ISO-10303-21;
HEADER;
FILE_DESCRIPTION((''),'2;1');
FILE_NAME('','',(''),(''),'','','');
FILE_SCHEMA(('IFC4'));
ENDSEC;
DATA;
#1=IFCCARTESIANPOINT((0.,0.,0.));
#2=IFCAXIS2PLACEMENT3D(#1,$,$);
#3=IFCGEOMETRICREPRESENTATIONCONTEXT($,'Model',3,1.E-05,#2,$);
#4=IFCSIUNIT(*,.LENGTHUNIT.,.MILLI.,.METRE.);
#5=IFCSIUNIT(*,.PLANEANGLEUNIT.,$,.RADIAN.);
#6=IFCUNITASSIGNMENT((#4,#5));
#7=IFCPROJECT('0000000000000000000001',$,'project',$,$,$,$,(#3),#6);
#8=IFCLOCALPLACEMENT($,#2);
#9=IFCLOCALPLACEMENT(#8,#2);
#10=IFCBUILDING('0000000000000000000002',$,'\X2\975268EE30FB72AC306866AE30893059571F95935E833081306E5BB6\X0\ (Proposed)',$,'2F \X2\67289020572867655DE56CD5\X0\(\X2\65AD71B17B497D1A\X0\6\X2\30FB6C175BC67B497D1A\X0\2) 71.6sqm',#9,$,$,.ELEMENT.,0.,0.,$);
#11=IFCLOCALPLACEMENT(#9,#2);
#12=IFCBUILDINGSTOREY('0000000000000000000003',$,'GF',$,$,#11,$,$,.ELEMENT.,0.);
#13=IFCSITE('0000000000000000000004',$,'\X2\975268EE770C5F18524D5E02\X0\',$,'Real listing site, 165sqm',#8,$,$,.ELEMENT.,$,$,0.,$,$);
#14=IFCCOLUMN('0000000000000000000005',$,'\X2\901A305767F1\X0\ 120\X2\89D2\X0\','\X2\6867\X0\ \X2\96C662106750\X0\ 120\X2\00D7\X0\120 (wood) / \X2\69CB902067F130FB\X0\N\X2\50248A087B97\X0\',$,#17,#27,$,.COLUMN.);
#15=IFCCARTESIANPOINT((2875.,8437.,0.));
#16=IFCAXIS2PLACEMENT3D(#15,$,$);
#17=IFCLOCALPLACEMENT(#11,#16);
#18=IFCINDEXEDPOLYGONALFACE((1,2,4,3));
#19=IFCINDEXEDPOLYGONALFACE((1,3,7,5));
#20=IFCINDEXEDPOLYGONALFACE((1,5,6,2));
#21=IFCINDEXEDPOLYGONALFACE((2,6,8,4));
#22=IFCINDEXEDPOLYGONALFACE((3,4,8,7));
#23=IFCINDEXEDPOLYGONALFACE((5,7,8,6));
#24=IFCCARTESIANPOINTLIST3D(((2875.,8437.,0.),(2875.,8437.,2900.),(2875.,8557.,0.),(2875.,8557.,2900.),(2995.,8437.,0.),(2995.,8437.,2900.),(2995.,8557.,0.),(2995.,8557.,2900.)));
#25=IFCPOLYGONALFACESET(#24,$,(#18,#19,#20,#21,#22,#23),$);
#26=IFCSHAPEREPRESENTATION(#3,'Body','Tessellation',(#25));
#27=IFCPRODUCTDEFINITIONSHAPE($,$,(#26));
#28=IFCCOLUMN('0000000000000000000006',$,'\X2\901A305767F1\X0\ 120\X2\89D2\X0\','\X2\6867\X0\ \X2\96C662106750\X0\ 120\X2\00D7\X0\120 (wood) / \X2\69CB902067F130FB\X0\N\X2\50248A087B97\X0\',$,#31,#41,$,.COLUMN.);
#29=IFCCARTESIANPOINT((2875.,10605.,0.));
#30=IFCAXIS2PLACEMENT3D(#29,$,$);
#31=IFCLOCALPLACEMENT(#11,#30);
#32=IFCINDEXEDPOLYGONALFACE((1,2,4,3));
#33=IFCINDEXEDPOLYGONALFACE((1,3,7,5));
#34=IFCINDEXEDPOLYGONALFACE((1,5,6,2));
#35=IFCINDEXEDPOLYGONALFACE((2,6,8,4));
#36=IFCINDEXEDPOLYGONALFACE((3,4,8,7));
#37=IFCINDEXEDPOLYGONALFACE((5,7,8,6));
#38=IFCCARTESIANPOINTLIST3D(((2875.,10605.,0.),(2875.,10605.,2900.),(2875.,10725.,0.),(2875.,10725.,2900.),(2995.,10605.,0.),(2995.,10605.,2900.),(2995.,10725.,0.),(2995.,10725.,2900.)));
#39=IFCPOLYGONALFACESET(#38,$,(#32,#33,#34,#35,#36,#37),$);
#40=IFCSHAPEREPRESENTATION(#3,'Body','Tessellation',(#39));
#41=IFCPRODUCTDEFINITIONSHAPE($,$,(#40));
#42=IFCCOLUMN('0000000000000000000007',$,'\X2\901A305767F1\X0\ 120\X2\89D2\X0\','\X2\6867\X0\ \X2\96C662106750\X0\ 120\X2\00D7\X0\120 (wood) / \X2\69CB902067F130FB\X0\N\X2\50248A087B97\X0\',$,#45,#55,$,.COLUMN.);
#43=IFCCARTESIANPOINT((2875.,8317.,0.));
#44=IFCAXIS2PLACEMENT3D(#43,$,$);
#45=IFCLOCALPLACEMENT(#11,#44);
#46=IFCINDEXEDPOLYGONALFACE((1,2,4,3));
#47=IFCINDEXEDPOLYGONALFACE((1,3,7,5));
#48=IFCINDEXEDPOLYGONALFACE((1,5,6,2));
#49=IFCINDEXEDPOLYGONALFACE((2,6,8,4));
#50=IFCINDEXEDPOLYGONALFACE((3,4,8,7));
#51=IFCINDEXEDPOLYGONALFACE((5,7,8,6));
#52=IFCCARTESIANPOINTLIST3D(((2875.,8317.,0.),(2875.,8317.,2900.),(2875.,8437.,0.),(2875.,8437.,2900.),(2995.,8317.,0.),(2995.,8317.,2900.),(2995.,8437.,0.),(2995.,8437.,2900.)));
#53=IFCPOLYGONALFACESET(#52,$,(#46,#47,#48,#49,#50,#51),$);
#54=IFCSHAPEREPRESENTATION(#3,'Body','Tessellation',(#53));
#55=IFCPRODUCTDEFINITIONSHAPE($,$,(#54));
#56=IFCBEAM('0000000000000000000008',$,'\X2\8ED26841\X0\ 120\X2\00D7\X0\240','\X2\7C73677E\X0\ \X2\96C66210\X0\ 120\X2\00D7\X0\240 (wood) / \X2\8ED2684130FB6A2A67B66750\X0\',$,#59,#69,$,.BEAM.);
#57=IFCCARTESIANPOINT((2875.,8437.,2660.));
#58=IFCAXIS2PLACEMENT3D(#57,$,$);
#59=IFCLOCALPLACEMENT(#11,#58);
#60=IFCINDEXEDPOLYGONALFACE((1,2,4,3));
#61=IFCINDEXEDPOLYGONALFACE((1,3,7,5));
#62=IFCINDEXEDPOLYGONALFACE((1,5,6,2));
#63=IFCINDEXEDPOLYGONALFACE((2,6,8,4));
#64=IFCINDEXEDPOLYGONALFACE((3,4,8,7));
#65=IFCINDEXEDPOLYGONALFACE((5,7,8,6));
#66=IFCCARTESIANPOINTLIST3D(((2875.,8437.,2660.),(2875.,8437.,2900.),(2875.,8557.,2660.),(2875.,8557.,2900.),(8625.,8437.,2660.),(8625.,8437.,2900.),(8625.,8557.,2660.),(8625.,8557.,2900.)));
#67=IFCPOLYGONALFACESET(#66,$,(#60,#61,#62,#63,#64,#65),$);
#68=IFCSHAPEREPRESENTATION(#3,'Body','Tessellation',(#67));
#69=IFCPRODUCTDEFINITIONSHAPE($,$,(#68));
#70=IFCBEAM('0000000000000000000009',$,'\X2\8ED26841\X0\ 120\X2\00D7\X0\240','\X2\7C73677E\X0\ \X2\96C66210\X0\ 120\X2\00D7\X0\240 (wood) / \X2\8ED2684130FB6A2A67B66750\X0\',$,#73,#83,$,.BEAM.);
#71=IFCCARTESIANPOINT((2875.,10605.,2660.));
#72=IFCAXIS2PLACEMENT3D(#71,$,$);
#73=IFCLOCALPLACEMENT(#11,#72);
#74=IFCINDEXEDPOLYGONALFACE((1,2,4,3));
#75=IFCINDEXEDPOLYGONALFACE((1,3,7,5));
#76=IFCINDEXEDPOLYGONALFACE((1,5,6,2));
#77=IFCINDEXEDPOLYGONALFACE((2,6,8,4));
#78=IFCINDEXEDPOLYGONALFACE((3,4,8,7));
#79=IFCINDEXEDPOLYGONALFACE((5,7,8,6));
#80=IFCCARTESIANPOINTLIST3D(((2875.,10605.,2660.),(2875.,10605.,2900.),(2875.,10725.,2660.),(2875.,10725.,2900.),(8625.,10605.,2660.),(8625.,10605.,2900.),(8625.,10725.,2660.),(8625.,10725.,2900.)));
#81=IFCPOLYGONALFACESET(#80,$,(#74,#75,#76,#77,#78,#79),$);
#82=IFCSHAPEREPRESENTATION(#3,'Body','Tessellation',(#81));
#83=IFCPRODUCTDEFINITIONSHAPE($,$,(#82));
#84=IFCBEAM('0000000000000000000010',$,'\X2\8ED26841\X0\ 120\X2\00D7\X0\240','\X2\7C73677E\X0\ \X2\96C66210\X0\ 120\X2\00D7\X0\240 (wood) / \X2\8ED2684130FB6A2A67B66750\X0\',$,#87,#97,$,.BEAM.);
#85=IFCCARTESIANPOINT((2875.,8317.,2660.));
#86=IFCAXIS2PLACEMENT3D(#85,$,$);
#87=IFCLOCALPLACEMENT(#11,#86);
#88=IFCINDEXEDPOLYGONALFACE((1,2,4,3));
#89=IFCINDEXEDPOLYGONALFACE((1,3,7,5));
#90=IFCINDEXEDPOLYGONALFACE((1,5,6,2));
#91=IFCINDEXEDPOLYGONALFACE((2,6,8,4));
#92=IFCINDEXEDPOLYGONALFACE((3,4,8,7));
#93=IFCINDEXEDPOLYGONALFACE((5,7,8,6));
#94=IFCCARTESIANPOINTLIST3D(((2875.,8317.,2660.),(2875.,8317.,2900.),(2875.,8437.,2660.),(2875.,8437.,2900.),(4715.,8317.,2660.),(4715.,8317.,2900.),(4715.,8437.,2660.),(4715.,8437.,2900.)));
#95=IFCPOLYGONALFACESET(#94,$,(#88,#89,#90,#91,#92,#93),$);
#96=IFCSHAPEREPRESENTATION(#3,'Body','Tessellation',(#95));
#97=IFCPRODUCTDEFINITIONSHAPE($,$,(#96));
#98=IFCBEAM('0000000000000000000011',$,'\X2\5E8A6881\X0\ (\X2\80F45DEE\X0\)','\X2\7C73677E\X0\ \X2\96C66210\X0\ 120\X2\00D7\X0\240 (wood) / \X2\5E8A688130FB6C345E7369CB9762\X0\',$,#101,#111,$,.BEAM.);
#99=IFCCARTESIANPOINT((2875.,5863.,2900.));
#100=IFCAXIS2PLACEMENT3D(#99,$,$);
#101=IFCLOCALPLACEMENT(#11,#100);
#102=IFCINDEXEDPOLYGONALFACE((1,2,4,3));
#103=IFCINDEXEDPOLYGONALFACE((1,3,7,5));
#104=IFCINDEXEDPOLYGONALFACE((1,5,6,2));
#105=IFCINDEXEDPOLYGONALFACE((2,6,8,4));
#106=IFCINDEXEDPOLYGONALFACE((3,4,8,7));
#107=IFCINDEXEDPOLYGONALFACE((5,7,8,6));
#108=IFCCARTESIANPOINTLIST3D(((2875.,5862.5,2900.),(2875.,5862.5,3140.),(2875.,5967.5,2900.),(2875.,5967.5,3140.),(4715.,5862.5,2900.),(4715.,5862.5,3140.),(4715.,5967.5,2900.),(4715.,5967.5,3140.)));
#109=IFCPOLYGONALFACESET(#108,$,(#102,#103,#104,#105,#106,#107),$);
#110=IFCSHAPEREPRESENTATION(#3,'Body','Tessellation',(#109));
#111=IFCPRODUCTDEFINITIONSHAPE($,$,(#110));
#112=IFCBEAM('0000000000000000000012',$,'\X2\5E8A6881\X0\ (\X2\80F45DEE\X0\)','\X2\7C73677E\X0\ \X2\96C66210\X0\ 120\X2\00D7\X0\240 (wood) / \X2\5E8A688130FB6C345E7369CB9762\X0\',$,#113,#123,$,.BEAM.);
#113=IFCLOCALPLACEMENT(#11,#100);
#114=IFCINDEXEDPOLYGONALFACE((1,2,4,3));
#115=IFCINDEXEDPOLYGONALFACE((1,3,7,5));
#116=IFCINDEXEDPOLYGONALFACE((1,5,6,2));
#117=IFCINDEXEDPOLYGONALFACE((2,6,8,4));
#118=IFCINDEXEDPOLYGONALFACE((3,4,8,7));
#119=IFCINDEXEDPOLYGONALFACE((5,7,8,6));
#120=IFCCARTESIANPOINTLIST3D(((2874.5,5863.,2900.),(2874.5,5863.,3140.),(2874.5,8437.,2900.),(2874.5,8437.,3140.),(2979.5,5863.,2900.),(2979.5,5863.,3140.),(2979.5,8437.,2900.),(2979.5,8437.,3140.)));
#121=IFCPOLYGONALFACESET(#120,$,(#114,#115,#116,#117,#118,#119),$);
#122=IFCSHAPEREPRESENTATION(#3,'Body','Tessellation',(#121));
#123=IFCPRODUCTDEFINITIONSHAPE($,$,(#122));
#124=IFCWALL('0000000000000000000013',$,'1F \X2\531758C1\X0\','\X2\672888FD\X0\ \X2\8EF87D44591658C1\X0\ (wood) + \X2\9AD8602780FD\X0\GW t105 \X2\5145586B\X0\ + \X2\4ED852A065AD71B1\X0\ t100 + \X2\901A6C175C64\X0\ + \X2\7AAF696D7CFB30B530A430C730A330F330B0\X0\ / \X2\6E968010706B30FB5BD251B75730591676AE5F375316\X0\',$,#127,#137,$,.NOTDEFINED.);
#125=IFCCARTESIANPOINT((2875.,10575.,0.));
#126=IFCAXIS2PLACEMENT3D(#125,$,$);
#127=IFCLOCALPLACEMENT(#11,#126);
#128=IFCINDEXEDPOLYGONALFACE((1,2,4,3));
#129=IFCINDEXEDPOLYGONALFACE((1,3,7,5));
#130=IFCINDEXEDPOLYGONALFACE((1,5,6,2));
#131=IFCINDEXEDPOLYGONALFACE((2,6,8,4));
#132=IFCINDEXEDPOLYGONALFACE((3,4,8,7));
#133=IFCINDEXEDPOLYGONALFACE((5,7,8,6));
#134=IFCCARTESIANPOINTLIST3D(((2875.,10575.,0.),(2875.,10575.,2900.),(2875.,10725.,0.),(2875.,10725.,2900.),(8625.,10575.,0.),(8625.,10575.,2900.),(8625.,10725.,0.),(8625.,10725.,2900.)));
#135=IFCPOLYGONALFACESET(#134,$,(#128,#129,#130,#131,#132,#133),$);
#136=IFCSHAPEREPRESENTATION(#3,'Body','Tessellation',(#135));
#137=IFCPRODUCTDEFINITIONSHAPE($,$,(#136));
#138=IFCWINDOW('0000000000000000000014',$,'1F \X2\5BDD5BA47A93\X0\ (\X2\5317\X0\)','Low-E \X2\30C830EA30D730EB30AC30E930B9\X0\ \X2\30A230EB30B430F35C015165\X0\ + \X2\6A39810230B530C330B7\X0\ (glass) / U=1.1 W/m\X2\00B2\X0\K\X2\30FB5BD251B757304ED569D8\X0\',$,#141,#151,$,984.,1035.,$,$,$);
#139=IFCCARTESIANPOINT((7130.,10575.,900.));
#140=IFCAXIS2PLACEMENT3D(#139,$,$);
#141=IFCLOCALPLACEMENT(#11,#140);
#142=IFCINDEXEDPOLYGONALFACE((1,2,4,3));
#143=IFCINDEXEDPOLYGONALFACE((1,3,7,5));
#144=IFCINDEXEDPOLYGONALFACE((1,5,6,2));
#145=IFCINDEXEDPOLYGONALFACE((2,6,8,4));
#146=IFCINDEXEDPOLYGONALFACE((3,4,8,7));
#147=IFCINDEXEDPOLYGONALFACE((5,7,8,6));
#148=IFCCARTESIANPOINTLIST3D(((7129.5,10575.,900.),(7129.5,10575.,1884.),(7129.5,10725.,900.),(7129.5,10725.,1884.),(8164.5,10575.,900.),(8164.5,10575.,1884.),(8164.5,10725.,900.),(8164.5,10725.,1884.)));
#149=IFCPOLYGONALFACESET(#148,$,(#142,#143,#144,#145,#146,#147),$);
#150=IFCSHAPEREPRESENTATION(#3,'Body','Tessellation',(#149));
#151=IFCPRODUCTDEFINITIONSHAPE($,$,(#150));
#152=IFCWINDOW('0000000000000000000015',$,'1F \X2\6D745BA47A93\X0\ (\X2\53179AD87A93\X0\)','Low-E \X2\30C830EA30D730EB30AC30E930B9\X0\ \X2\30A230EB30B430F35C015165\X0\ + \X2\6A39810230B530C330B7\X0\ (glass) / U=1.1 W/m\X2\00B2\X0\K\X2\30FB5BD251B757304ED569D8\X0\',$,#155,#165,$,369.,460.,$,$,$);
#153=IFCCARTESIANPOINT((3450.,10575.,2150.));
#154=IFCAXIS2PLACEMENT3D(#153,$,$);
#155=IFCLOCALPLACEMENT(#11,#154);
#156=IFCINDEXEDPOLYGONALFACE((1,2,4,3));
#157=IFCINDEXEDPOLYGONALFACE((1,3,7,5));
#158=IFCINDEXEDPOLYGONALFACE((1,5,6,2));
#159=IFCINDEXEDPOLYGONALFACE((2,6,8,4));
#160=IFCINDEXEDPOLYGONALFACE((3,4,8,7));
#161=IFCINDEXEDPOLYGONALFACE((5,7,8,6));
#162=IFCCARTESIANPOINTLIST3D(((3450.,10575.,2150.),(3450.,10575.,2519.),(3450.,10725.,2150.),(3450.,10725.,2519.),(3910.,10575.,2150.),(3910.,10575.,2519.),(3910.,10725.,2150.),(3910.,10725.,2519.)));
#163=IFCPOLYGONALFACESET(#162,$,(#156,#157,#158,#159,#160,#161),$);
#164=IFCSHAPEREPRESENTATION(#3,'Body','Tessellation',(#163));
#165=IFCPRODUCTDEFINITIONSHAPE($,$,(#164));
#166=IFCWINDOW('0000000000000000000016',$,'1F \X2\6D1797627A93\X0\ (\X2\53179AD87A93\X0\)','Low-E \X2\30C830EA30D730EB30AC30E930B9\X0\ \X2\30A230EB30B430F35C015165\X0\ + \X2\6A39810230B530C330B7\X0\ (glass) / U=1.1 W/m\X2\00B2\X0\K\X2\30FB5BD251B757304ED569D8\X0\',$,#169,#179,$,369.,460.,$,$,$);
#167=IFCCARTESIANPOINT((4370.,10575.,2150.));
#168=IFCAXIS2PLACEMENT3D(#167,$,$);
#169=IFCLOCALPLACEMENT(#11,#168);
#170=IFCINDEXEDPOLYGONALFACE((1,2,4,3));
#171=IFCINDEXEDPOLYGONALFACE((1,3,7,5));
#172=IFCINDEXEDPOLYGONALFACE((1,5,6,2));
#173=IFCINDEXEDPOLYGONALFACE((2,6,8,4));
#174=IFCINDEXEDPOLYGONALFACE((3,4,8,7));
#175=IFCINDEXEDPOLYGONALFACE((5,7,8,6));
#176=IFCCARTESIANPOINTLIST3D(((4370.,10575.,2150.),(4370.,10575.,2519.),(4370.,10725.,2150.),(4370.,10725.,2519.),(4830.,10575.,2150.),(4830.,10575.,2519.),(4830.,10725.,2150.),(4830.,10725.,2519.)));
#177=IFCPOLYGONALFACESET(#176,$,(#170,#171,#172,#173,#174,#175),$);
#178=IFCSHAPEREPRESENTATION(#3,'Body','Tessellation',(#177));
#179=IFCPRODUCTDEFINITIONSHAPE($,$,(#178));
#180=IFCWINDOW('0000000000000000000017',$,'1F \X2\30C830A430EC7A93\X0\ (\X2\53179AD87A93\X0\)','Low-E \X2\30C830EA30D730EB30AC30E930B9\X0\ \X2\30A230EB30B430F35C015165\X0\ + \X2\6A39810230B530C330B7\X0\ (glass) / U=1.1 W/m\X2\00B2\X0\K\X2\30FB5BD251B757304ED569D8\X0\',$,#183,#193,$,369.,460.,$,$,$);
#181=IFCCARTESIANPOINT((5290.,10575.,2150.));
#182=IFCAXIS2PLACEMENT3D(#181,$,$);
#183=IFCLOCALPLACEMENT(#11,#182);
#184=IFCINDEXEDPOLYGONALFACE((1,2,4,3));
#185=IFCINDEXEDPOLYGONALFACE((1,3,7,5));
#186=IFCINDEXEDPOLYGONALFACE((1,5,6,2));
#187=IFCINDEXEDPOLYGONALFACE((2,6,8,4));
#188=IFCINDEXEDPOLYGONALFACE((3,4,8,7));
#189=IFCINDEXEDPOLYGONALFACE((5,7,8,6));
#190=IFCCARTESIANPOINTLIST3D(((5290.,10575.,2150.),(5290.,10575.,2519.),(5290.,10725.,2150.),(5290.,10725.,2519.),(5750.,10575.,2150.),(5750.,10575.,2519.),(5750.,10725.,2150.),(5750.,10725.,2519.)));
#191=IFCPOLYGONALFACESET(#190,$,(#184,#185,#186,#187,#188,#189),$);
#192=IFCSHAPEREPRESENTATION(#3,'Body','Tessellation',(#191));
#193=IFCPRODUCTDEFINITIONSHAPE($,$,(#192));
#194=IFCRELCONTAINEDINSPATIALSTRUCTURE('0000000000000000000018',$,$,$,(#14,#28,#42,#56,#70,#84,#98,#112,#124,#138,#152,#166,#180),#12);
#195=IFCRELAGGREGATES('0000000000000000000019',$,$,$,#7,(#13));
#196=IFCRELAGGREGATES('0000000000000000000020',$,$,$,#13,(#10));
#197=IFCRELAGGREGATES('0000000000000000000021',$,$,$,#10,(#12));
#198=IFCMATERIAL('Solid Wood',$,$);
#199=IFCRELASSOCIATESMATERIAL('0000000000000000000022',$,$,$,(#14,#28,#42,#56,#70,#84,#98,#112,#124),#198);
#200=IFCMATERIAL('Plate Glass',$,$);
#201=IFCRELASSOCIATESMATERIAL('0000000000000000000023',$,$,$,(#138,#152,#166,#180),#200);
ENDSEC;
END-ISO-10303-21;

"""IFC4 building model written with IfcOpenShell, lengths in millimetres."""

from ifc_helpers import new_model, si_unit, frame, frame_2d, origin, place, context, project, spatial, rectangle, extrude, material, element, fill, save


model = new_model("IFC4")

# Units and contexts
model_context = context("Model", 3, precision=1e-05, world=origin())
ifc_project = project(units=[si_unit("LENGTHUNIT", "METRE", prefix="MILLI"), si_unit("PLANEANGLEUNIT", "RADIAN")], contexts=[model_context])

# Site, building, storey
site_placement = place(None, origin())
site = spatial("IfcSite", under=ifc_project, at=site_placement, Name="青森県弘前市", ObjectType="Real listing site, 165sqm", CompositionType="ELEMENT", RefElevation=0.0)
building_placement = place(site_placement, origin())
building = spatial("IfcBuilding", under=site, at=building_placement, Name="青森・犬と暮らす土間広めの家 (Proposed)", ObjectType="2F 木造在来工法(断熱等級6・気密等級2) 71.6sqm", CompositionType="ELEMENT", ElevationOfRefHeight=0.0, ElevationOfTerrain=0.0)
storey_placement = place(building_placement, origin())
storey = spatial("IfcBuildingStorey", under=building, at=storey_placement, Name="GF", CompositionType="ELEMENT", Elevation=0.0)

# Columns
ifc_material_1 = material(Name="Solid Wood")
column_1_placement = place(storey_placement, frame((2875.0, 8437.0, 0.0)))
element("IfcColumn", 1, at=column_1_placement, inside=storey, material=ifc_material_1, Name="通し柱 120角", Description="桧 集成材 120×120 (wood) / 構造柱・N値計算", PredefinedType="COLUMN", context=model_context, shape_type="SweptSolid", body=[
    extrude(rectangle(XDim=120.0, YDim=120.0, at=frame_2d((60.0, 60.0))), frame((2875.0, 8437.0, 0.0)), (0.0, 0.0, 1.0), 2900.0),
])
column_2_placement = place(storey_placement, frame((2875.0, 10605.0, 0.0)))
element("IfcColumn", 2, at=column_2_placement, inside=storey, material=ifc_material_1, Name="通し柱 120角", Description="桧 集成材 120×120 (wood) / 構造柱・N値計算", PredefinedType="COLUMN", context=model_context, shape_type="SweptSolid", body=[
    extrude(rectangle(XDim=120.0, YDim=120.0, at=frame_2d((60.0, 60.0))), frame((2875.0, 10605.0, 0.0)), (0.0, 0.0, 1.0), 2900.0),
])
column_3_placement = place(storey_placement, frame((2875.0, 8317.0, 0.0)))
element("IfcColumn", 3, at=column_3_placement, inside=storey, material=ifc_material_1, Name="通し柱 120角", Description="桧 集成材 120×120 (wood) / 構造柱・N値計算", PredefinedType="COLUMN", context=model_context, shape_type="SweptSolid", body=[
    extrude(rectangle(XDim=120.0, YDim=120.0, at=frame_2d((60.0, 60.0))), frame((2875.0, 8317.0, 0.0)), (0.0, 0.0, 1.0), 2900.0),
])

# Beams
beam_1_placement = place(storey_placement, frame((2875.0, 8437.0, 2660.0)))
element("IfcBeam", 4, at=beam_1_placement, inside=storey, material=ifc_material_1, Name="軒桁 120×240", Description="米松 集成 120×240 (wood) / 軒桁・横架材", PredefinedType="BEAM", context=model_context, shape_type="SweptSolid", body=[
    extrude(rectangle(XDim=5750.0, YDim=120.0, at=frame_2d((2875.0, 60.0))), frame((2875.0, 8437.0, 2660.0)), (0.0, 0.0, 1.0), 240.0),
])
beam_2_placement = place(storey_placement, frame((2875.0, 10605.0, 2660.0)))
element("IfcBeam", 5, at=beam_2_placement, inside=storey, material=ifc_material_1, Name="軒桁 120×240", Description="米松 集成 120×240 (wood) / 軒桁・横架材", PredefinedType="BEAM", context=model_context, shape_type="SweptSolid", body=[
    extrude(rectangle(XDim=5750.0, YDim=120.0, at=frame_2d((2875.0, 60.0))), frame((2875.0, 10605.0, 2660.0)), (0.0, 0.0, 1.0), 240.0),
])
beam_3_placement = place(storey_placement, frame((2875.0, 8317.0, 2660.0)))
element("IfcBeam", 6, at=beam_3_placement, inside=storey, material=ifc_material_1, Name="軒桁 120×240", Description="米松 集成 120×240 (wood) / 軒桁・横架材", PredefinedType="BEAM", context=model_context, shape_type="SweptSolid", body=[
    extrude(rectangle(XDim=1840.0, YDim=120.0, at=frame_2d((920.0, 60.0))), frame((2875.0, 8317.0, 2660.0)), (0.0, 0.0, 1.0), 240.0),
])
beam_4_placement = place(storey_placement, frame((2875.0, 5863.0, 2900.0)))
element("IfcBeam", 7, at=beam_4_placement, inside=storey, material=ifc_material_1, Name="床梁 (胴差)", Description="米松 集成 120×240 (wood) / 床梁・水平構面", PredefinedType="BEAM", context=model_context, shape_type="SweptSolid", body=[
    extrude(rectangle(XDim=1840.0, YDim=105.0, at=frame_2d((920.0, 52.0))), frame((2875.0, 5863.0, 2900.0)), (0.0, 0.0, 1.0), 240.0),
])
beam_5_placement = place(storey_placement, frame((2875.0, 5863.0, 2900.0)))
element("IfcBeam", 8, at=beam_5_placement, inside=storey, material=ifc_material_1, Name="床梁 (胴差)", Description="米松 集成 120×240 (wood) / 床梁・水平構面", PredefinedType="BEAM", context=model_context, shape_type="SweptSolid", body=[
    extrude(rectangle(XDim=105.0, YDim=2574.0, at=frame_2d((52.0, 1287.0))), frame((2875.0, 5863.0, 2900.0)), (0.0, 0.0, 1.0), 240.0),
])

# Wall, openings, windows
wall_1_placement = place(storey_placement, frame((2875.0, 10575.0, 0.0)))
wall_1 = element("IfcWall", 9, at=wall_1_placement, inside=storey, material=ifc_material_1, Name="1F 北壁", Description="木製 軸組外壁 (wood) + 高性能GW t105 充填 + 付加断熱 t100 + 通気層 + 窯業系サイディング / 準耐火・寒冷地外皮強化", PredefinedType="NOTDEFINED", context=model_context, shape_type="SweptSolid", body=[
    extrude(rectangle(XDim=5750.0, YDim=150.0, at=frame_2d((2875.0, 75.0))), frame((2875.0, 10575.0, 0.0)), (0.0, 0.0, 1.0), 2900.0),
])
opening_1_placement = place(storey_placement, frame((7130.0, 10575.0, 900.0)))
opening_1 = element("IfcOpeningElement", 10, at=opening_1_placement, cuts=wall_1, PredefinedType="NOTDEFINED", context=model_context, shape_type="SweptSolid", body=[
    extrude(rectangle(XDim=1035.0, YDim=150.0, at=frame_2d((517.0, 75.0))), frame((7130.0, 10575.0, 900.0)), (0.0, 0.0, 1.0), 984.0),
])
opening_2_placement = place(storey_placement, frame((3450.0, 10575.0, 2150.0)))
opening_2 = element("IfcOpeningElement", 11, at=opening_2_placement, cuts=wall_1, PredefinedType="NOTDEFINED", context=model_context, shape_type="SweptSolid", body=[
    extrude(rectangle(XDim=460.0, YDim=150.0, at=frame_2d((230.0, 75.0))), frame((3450.0, 10575.0, 2150.0)), (0.0, 0.0, 1.0), 369.0),
])
opening_3_placement = place(storey_placement, frame((4370.0, 10575.0, 2150.0)))
opening_3 = element("IfcOpeningElement", 12, at=opening_3_placement, cuts=wall_1, PredefinedType="NOTDEFINED", context=model_context, shape_type="SweptSolid", body=[
    extrude(rectangle(XDim=460.0, YDim=150.0, at=frame_2d((230.0, 75.0))), frame((4370.0, 10575.0, 2150.0)), (0.0, 0.0, 1.0), 369.0),
])
opening_4_placement = place(storey_placement, frame((5290.0, 10575.0, 2150.0)))
opening_4 = element("IfcOpeningElement", 13, at=opening_4_placement, cuts=wall_1, PredefinedType="NOTDEFINED", context=model_context, shape_type="SweptSolid", body=[
    extrude(rectangle(XDim=460.0, YDim=150.0, at=frame_2d((230.0, 75.0))), frame((5290.0, 10575.0, 2150.0)), (0.0, 0.0, 1.0), 369.0),
])
ifc_material_2 = material(Name="Plate Glass")
window_1_placement = place(storey_placement, frame((7130.0, 10575.0, 900.0)))
window_1 = element("IfcWindow", 14, at=window_1_placement, inside=storey, material=ifc_material_2, Name="1F 寝室窓 (北)", Description="Low-E トリプルガラス アルゴン封入 + 樹脂サッシ (glass) / U=1.1 W/m²K・寒冷地仕様", OverallHeight=984.0, OverallWidth=1035.0, context=model_context, shape_type="SweptSolid", body=[
    extrude(rectangle(XDim=1035.0, YDim=150.0, at=frame_2d((517.0, 75.0))), frame((7130.0, 10575.0, 900.0)), (0.0, 0.0, 1.0), 984.0),
])
fill(opening_1, window_1)
window_2_placement = place(storey_placement, frame((3450.0, 10575.0, 2150.0)))
window_2 = element("IfcWindow", 15, at=window_2_placement, inside=storey, material=ifc_material_2, Name="1F 浴室窓 (北高窓)", Description="Low-E トリプルガラス アルゴン封入 + 樹脂サッシ (glass) / U=1.1 W/m²K・寒冷地仕様", OverallHeight=369.0, OverallWidth=460.0, context=model_context, shape_type="SweptSolid", body=[
    extrude(rectangle(XDim=460.0, YDim=150.0, at=frame_2d((230.0, 75.0))), frame((3450.0, 10575.0, 2150.0)), (0.0, 0.0, 1.0), 369.0),
])
fill(opening_2, window_2)
window_3_placement = place(storey_placement, frame((4370.0, 10575.0, 2150.0)))
window_3 = element("IfcWindow", 16, at=window_3_placement, inside=storey, material=ifc_material_2, Name="1F 洗面窓 (北高窓)", Description="Low-E トリプルガラス アルゴン封入 + 樹脂サッシ (glass) / U=1.1 W/m²K・寒冷地仕様", OverallHeight=369.0, OverallWidth=460.0, context=model_context, shape_type="SweptSolid", body=[
    extrude(rectangle(XDim=460.0, YDim=150.0, at=frame_2d((230.0, 75.0))), frame((4370.0, 10575.0, 2150.0)), (0.0, 0.0, 1.0), 369.0),
])
fill(opening_3, window_3)
window_4_placement = place(storey_placement, frame((5290.0, 10575.0, 2150.0)))
window_4 = element("IfcWindow", 17, at=window_4_placement, inside=storey, material=ifc_material_2, Name="1F トイレ窓 (北高窓)", Description="Low-E トリプルガラス アルゴン封入 + 樹脂サッシ (glass) / U=1.1 W/m²K・寒冷地仕様", OverallHeight=369.0, OverallWidth=460.0, context=model_context, shape_type="SweptSolid", body=[
    extrude(rectangle(XDim=460.0, YDim=150.0, at=frame_2d((230.0, 75.0))), frame((5290.0, 10575.0, 2150.0)), (0.0, 0.0, 1.0), 369.0),
])
fill(opening_4, window_4)

save(model, "model.ifc")
